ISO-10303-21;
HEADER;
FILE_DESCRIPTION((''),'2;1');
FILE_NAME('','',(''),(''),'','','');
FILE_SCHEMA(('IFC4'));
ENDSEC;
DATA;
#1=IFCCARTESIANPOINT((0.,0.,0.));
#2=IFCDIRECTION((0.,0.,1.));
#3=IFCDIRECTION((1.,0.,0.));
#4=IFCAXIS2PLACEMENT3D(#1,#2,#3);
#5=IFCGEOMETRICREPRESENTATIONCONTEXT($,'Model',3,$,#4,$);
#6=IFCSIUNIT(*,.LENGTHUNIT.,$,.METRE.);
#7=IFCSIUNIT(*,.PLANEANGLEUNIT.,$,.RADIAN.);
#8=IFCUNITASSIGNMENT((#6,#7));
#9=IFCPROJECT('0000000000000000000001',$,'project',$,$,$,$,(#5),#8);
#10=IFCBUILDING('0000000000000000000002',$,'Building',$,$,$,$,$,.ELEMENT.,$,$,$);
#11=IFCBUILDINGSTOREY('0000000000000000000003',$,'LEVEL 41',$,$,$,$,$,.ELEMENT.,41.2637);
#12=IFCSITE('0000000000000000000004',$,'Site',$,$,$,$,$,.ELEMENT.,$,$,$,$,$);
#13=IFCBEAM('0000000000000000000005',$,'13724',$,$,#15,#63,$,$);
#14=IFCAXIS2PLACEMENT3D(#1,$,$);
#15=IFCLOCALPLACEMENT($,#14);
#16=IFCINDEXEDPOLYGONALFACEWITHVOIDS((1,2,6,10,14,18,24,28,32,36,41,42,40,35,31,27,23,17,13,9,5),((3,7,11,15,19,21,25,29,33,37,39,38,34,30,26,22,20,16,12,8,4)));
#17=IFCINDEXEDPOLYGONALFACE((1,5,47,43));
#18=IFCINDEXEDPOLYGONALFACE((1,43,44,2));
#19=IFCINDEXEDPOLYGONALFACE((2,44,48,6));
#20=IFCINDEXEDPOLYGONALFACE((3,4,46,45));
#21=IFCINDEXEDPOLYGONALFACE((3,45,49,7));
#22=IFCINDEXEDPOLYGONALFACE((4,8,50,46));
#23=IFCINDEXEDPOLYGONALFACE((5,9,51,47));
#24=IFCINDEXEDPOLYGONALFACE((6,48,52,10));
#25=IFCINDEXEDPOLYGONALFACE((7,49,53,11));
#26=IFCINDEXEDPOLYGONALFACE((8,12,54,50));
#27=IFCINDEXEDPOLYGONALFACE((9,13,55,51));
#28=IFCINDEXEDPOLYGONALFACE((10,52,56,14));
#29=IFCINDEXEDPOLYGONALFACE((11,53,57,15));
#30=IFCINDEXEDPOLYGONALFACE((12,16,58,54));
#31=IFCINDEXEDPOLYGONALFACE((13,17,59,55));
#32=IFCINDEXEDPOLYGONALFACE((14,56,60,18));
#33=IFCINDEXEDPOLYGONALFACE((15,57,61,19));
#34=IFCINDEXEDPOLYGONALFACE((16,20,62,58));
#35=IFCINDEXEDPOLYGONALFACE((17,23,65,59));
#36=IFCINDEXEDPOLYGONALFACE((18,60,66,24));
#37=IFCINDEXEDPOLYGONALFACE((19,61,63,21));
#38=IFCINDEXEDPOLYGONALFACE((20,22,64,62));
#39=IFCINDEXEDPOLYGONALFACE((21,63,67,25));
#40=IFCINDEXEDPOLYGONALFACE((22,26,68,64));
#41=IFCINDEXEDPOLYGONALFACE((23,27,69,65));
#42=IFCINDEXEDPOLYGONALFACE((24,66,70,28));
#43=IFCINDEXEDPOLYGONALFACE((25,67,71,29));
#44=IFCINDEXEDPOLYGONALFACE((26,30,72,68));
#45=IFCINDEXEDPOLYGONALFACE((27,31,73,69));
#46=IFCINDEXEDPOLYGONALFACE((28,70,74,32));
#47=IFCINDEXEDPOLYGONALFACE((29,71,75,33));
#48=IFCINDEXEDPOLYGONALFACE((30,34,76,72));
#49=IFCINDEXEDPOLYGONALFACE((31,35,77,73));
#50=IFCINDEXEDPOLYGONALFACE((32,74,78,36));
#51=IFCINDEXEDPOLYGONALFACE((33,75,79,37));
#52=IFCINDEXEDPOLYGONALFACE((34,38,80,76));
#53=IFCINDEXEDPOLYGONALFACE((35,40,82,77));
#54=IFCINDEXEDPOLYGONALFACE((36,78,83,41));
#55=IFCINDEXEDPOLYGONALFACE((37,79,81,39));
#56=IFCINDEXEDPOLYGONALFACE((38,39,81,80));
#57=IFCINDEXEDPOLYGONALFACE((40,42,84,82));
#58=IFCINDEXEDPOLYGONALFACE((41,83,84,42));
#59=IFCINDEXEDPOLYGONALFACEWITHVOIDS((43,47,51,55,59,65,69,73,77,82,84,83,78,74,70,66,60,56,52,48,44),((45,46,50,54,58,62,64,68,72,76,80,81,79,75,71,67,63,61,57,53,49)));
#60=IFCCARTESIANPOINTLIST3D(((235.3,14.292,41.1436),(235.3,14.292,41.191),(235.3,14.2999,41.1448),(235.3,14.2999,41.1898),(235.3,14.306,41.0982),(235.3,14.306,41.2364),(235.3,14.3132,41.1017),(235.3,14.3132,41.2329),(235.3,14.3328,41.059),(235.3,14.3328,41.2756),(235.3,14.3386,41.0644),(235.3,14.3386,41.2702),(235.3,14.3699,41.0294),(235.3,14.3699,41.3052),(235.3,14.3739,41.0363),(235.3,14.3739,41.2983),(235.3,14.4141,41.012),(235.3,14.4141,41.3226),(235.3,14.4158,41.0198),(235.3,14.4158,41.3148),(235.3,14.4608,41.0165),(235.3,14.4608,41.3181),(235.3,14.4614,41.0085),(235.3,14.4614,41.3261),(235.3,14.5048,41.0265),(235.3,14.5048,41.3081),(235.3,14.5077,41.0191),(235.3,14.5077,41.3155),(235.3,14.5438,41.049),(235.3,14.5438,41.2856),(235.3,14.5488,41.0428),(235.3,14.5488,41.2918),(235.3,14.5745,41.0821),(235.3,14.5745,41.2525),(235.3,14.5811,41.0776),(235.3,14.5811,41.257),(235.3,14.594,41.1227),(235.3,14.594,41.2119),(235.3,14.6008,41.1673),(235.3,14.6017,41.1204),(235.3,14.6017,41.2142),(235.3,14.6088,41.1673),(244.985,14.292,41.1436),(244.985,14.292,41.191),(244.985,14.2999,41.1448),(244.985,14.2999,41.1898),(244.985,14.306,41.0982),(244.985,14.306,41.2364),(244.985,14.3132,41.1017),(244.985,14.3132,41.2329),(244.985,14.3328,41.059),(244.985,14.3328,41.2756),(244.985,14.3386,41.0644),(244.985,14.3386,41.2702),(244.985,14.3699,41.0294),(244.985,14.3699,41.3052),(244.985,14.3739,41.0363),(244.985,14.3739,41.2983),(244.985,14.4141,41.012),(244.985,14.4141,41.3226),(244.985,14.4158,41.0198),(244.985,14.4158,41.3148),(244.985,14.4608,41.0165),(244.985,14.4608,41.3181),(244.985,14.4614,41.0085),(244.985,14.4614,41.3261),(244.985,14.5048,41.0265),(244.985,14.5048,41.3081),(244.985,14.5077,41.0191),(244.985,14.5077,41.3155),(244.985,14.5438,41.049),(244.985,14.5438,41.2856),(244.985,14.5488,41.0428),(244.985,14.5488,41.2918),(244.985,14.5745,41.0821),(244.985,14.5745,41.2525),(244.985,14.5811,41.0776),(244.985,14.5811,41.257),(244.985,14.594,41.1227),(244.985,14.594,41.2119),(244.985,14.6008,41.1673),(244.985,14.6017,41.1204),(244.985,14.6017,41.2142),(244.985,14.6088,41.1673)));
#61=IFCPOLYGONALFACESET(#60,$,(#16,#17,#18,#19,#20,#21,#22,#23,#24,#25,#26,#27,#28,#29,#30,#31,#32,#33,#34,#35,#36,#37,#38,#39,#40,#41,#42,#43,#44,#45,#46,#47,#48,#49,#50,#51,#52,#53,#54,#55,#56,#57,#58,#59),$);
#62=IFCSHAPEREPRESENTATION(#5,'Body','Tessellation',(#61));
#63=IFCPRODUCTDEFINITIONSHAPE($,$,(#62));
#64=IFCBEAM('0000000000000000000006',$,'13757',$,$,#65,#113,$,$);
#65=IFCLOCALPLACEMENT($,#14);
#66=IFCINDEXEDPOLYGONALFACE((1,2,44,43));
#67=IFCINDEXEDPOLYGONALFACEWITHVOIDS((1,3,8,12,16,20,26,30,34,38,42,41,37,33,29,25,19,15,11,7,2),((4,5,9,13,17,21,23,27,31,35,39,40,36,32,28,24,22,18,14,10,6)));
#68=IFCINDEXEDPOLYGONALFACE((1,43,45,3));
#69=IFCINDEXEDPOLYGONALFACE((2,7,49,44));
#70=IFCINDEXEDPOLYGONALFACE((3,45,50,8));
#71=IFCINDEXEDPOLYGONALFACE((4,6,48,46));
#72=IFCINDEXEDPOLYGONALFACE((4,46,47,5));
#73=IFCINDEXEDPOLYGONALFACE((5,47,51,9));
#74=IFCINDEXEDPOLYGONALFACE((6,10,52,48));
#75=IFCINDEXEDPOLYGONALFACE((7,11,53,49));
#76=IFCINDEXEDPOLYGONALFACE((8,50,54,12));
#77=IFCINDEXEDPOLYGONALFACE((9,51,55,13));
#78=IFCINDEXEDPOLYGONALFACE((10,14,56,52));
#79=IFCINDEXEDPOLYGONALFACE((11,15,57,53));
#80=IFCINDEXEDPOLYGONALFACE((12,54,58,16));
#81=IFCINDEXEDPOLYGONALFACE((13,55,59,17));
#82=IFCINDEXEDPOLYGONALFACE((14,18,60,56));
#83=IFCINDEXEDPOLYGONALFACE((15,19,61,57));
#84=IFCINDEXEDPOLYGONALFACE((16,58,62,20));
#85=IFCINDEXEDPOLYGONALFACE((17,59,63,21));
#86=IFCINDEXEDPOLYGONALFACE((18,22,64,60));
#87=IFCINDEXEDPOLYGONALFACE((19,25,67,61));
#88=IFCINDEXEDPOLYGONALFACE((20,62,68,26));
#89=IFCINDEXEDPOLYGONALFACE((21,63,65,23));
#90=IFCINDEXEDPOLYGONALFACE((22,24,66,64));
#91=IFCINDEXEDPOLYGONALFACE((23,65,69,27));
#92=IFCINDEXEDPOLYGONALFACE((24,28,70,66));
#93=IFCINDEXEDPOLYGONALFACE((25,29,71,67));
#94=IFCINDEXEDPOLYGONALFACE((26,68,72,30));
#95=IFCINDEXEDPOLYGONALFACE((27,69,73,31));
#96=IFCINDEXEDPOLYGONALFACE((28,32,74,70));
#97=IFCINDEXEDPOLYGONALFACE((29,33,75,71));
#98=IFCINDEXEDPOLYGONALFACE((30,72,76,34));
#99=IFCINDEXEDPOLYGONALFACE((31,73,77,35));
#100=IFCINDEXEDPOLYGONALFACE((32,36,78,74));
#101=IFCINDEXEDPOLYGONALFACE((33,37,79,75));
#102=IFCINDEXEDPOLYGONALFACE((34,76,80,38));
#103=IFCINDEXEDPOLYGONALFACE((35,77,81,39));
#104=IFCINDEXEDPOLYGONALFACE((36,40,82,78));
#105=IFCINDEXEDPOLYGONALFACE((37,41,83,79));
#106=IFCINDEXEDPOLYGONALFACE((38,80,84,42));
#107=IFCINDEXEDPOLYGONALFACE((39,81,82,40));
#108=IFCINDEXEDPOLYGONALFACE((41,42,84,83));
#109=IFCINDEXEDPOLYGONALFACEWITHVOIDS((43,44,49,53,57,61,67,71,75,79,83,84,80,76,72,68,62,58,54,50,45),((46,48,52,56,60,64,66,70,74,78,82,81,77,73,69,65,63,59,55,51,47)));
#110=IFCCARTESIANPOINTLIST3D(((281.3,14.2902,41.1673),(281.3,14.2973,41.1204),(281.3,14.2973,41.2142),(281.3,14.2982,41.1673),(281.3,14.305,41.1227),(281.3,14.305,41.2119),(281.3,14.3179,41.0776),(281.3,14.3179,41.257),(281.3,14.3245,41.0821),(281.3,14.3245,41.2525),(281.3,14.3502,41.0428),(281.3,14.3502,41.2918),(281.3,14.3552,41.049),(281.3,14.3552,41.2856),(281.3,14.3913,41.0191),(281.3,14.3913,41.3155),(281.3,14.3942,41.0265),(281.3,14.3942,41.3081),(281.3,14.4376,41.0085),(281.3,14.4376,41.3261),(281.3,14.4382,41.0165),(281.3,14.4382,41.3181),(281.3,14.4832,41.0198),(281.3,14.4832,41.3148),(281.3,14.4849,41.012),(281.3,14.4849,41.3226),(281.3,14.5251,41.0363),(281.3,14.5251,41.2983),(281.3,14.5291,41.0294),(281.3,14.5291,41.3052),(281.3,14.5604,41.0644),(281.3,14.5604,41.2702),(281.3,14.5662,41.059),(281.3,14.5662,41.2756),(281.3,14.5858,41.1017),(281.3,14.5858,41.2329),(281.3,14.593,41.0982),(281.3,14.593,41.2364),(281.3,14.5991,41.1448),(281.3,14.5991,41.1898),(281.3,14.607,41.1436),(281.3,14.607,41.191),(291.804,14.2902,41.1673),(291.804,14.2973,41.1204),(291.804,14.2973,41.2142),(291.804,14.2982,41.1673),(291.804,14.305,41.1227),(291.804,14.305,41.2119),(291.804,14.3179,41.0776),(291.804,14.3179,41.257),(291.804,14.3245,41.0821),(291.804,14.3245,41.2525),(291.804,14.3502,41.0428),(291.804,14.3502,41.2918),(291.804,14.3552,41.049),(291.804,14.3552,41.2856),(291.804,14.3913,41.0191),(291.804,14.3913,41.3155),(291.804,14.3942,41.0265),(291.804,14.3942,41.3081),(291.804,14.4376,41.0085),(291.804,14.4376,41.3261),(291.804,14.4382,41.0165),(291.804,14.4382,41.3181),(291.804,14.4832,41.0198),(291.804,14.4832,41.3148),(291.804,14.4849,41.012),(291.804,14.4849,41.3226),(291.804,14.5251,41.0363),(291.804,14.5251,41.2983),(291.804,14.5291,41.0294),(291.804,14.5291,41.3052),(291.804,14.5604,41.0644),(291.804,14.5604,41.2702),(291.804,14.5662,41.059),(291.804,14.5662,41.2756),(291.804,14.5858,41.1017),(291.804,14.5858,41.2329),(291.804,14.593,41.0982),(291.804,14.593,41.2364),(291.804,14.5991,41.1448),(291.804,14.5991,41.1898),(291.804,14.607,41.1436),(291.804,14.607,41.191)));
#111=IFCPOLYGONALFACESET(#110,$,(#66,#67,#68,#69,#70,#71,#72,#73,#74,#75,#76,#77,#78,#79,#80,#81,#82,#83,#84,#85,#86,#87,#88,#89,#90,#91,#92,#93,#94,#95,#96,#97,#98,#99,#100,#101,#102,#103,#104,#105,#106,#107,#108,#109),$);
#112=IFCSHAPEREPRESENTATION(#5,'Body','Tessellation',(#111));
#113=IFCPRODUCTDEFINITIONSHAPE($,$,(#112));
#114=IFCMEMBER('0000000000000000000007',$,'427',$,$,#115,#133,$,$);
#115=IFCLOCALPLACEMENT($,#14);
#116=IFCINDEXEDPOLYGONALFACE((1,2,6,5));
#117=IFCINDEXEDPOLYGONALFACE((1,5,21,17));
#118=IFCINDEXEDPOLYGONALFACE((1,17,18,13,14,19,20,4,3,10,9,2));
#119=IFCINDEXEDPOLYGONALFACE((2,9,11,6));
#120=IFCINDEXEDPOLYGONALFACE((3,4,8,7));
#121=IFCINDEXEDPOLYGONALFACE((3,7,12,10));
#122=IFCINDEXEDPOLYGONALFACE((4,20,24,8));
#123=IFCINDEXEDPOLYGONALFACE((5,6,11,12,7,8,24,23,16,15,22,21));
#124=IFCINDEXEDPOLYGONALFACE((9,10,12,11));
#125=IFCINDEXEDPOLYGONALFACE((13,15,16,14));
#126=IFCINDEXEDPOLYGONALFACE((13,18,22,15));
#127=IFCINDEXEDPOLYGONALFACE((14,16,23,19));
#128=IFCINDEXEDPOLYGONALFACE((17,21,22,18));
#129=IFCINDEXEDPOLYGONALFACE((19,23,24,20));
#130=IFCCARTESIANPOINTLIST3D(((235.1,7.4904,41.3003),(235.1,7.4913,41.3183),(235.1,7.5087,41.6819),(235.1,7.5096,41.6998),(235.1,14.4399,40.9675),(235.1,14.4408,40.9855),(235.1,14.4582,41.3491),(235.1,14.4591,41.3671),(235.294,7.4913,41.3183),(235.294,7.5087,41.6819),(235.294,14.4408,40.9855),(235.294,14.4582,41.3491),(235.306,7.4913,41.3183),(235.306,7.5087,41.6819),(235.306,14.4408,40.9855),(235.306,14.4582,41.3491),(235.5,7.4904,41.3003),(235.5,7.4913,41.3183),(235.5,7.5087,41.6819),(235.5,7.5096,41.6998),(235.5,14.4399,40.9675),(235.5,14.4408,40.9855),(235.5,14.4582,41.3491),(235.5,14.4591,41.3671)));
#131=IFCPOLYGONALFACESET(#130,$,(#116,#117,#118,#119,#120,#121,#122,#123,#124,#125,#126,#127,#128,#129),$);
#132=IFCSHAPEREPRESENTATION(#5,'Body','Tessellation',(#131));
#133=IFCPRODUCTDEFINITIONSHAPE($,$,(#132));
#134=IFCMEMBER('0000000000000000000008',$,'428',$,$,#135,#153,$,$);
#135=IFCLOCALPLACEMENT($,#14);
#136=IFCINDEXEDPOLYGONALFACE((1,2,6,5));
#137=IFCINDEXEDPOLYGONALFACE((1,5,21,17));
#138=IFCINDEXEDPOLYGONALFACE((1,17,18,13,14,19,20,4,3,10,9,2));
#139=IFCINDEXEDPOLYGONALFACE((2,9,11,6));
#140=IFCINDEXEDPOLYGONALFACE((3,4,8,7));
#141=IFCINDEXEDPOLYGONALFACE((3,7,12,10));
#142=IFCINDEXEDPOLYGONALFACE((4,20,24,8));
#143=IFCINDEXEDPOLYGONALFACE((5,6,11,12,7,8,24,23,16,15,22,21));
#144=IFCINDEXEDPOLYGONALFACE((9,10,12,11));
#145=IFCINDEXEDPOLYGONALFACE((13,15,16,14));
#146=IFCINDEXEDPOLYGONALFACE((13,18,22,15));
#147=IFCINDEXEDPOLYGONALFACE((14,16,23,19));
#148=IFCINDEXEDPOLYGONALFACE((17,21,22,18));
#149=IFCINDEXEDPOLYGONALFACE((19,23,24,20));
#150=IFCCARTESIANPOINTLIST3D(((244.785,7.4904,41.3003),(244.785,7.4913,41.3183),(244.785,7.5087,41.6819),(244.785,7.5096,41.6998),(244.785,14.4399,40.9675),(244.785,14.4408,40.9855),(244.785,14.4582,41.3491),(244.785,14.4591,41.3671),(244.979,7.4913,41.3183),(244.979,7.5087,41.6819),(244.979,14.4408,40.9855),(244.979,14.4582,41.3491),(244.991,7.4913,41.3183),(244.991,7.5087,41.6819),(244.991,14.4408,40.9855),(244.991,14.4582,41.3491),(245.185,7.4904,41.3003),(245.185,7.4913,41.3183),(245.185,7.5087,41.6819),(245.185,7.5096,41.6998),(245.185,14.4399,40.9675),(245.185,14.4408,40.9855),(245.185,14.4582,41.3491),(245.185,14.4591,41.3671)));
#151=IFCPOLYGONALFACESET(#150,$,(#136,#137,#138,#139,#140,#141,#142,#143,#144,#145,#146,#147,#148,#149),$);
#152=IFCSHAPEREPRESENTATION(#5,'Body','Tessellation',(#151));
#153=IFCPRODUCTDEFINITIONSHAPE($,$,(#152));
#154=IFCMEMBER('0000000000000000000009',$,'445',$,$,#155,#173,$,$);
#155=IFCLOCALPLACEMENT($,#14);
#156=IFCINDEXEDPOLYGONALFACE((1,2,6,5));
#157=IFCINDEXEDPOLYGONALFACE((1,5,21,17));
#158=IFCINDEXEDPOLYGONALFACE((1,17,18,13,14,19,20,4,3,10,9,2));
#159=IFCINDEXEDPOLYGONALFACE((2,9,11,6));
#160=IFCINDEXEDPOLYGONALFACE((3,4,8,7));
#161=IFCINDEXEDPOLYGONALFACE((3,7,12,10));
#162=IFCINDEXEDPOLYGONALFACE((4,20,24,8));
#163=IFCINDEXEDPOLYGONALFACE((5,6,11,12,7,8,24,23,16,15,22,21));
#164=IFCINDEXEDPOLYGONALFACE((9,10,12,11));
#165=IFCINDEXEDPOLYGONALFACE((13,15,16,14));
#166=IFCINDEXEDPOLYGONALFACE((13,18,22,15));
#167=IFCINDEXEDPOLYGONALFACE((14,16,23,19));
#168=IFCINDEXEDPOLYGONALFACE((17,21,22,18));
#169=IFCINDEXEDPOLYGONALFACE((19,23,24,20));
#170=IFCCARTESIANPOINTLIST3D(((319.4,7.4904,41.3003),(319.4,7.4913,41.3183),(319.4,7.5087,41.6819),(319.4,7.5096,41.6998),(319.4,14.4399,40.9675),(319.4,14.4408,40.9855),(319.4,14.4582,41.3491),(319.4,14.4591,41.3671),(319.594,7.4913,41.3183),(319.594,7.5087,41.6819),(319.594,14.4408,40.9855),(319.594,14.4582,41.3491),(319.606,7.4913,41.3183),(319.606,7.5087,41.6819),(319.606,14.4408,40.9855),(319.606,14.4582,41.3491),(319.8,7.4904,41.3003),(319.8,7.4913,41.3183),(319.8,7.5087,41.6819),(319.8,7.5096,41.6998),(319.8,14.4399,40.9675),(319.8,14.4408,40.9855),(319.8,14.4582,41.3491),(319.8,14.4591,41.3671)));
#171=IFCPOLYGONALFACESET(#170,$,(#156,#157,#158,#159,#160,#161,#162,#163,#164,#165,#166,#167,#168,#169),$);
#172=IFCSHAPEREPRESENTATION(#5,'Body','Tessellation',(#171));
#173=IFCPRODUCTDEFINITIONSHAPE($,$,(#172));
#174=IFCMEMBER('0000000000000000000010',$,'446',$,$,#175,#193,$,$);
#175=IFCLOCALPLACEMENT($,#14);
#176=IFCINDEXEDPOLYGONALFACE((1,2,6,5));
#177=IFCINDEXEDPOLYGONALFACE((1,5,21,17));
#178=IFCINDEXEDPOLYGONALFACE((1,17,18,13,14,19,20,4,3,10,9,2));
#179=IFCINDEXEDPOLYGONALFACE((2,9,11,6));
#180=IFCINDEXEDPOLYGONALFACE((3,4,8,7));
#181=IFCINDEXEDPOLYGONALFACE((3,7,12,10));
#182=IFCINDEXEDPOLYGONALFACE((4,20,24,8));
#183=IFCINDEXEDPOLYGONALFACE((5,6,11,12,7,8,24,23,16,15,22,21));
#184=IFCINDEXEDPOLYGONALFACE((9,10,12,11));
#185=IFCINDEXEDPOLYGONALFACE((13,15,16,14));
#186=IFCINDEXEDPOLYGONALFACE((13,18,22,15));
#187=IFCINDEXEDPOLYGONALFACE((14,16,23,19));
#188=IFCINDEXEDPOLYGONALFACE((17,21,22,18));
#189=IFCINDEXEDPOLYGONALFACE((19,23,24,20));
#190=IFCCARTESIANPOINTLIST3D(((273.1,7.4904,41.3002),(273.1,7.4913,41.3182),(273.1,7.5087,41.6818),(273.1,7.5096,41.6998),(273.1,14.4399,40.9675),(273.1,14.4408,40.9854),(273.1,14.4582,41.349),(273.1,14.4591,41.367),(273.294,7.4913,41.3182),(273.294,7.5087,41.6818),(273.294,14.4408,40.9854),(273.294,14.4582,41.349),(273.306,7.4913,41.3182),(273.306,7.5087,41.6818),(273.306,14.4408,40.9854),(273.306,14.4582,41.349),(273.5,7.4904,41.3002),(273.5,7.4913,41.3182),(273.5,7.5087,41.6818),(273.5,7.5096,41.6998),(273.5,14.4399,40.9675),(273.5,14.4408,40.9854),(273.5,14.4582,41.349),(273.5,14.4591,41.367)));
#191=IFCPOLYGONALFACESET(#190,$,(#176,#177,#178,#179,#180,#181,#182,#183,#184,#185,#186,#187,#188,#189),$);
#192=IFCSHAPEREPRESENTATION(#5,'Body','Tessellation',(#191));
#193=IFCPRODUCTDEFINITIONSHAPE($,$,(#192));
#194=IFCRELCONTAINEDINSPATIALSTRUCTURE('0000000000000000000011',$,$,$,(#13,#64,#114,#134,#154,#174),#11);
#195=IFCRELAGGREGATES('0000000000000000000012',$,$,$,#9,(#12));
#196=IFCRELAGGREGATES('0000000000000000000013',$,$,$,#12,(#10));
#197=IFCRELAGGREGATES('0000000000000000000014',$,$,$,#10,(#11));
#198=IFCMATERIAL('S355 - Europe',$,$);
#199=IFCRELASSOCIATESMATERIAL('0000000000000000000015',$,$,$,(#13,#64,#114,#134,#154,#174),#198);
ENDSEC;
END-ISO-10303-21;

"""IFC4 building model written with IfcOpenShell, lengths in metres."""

from ifc_helpers import new_model, si_unit, frame, origin_with_axes, origin_2d_with_axis, place, context, project, spatial, hollow_circle, i_section, extrude, material, material_profile, profile_set, profile_usage, element, save


model = new_model("IFC4")

# Units and contexts
model_context = context("Model", 3, world=origin_with_axes())
ifc_project = project(units=[si_unit("LENGTHUNIT", "METRE"), si_unit("PLANEANGLEUNIT", "RADIAN")], contexts=[model_context])

# Site, building, storey
site = spatial("IfcSite", under=ifc_project, Name="Site", CompositionType="ELEMENT")
building = spatial("IfcBuilding", under=site, Name="Building", CompositionType="ELEMENT")
storey = spatial("IfcBuildingStorey", under=building, Name="LEVEL 41", CompositionType="ELEMENT", Elevation=41.2637)

# Beams
ifc_material = material(Name="S355 - Europe")
ifc_material_profile_1 = material_profile(ifc_material, hollow_circle(Radius=0.1593, WallThickness=0.008, at=origin_2d_with_axis()))
ifc_profile_set_1 = profile_set([ifc_material_profile_1])
ifc_profile_usage_1 = profile_usage(ifc_profile_set_1, cardinal=10)
beam_1_placement = place(None, frame((235.3, 14.4495, 41.1673), z_axis=(1.0, 0.0, 0.0), x_axis=(0.0, 1.0, 0.0)))
element("IfcBeam", 1, at=beam_1_placement, inside=storey, material=ifc_profile_usage_1, Name="13724", context=model_context, shape_type="SweptSolid", body=[
    extrude(hollow_circle(Radius=0.1593, WallThickness=0.008, at=origin_2d_with_axis()), origin_with_axes(), (0.0, 0.0, 1.0), 9.685),
])
ifc_material_profile_2 = material_profile(ifc_material, hollow_circle(Radius=0.1593, WallThickness=0.008, at=origin_2d_with_axis()))
ifc_profile_set_2 = profile_set([ifc_material_profile_2])
ifc_profile_usage_2 = profile_usage(ifc_profile_set_2, cardinal=10)
beam_2_placement = place(None, frame((291.804, 14.4495, 41.1673), z_axis=(-1.0, 0.0, 0.0), x_axis=(0.0, -1.0, 0.0)))
element("IfcBeam", 2, at=beam_2_placement, inside=storey, material=ifc_profile_usage_2, Name="13757", context=model_context, shape_type="SweptSolid", body=[
    extrude(hollow_circle(Radius=0.1593, WallThickness=0.008, at=origin_2d_with_axis()), origin_with_axes(), (0.0, 0.0, 1.0), 10.504),
])

# Members
ifc_material_profile_3 = material_profile(ifc_material, i_section(OverallWidth=0.4, OverallDepth=0.4, WebThickness=0.012, FlangeThickness=0.018, at=origin_2d_with_axis()))
ifc_profile_set_3 = profile_set([ifc_material_profile_3])
ifc_profile_usage_3 = profile_usage(ifc_profile_set_3, cardinal=10)
member_1_placement = place(None, frame((235.3, 14.4495, 41.1673), z_axis=(0.0, -0.998856, 0.047828), x_axis=(1.0, 0.0, 0.0)))
element("IfcMember", 3, at=member_1_placement, inside=storey, material=ifc_profile_usage_3, Name="427", context=model_context, shape_type="SweptSolid", body=[
    extrude(i_section(OverallWidth=0.4, OverallDepth=0.4, WebThickness=0.012, FlangeThickness=0.018, at=origin_2d_with_axis()), origin_with_axes(), (0.0, 0.0, 1.0), 6.9575),
])
ifc_material_profile_4 = material_profile(ifc_material, i_section(OverallWidth=0.4, OverallDepth=0.4, WebThickness=0.012, FlangeThickness=0.018, at=origin_2d_with_axis()))
ifc_profile_set_4 = profile_set([ifc_material_profile_4])
ifc_profile_usage_4 = profile_usage(ifc_profile_set_4, cardinal=10)
member_2_placement = place(None, frame((244.985, 14.4495, 41.1673), z_axis=(0.0, -0.998856, 0.047828), x_axis=(1.0, 0.0, 0.0)))
element("IfcMember", 4, at=member_2_placement, inside=storey, material=ifc_profile_usage_4, Name="428", context=model_context, shape_type="SweptSolid", body=[
    extrude(i_section(OverallWidth=0.4, OverallDepth=0.4, WebThickness=0.012, FlangeThickness=0.018, at=origin_2d_with_axis()), origin_with_axes(), (0.0, 0.0, 1.0), 6.9575),
])
ifc_material_profile_5 = material_profile(ifc_material, i_section(OverallWidth=0.4, OverallDepth=0.4, WebThickness=0.012, FlangeThickness=0.018, at=origin_2d_with_axis()))
ifc_profile_set_5 = profile_set([ifc_material_profile_5])
ifc_profile_usage_5 = profile_usage(ifc_profile_set_5, cardinal=10)
member_3_placement = place(None, frame((319.6, 14.4495, 41.1673), z_axis=(0.0, -0.998856, 0.047828), x_axis=(1.0, 0.0, 0.0)))
element("IfcMember", 5, at=member_3_placement, inside=storey, material=ifc_profile_usage_5, Name="445", context=model_context, shape_type="SweptSolid", body=[
    extrude(i_section(OverallWidth=0.4, OverallDepth=0.4, WebThickness=0.012, FlangeThickness=0.018, at=origin_2d_with_axis()), origin_with_axes(), (0.0, 0.0, 1.0), 6.9575),
])
ifc_material_profile_6 = material_profile(ifc_material, i_section(OverallWidth=0.4, OverallDepth=0.4, WebThickness=0.012, FlangeThickness=0.018, at=origin_2d_with_axis()))
ifc_profile_set_6 = profile_set([ifc_material_profile_6])
ifc_profile_usage_6 = profile_usage(ifc_profile_set_6, cardinal=10)
member_4_placement = place(None, frame((273.3, 7.5, 41.5), z_axis=(0.0, 0.998856, -0.047828), x_axis=(-1.0, 0.0, 0.0)))
element("IfcMember", 6, at=member_4_placement, inside=storey, material=ifc_profile_usage_6, Name="446", context=model_context, shape_type="SweptSolid", body=[
    extrude(i_section(OverallWidth=0.4, OverallDepth=0.4, WebThickness=0.012, FlangeThickness=0.018, at=origin_2d_with_axis()), origin_with_axes(), (0.0, 0.0, 1.0), 6.9575),
])

save(model, "model.ifc")
